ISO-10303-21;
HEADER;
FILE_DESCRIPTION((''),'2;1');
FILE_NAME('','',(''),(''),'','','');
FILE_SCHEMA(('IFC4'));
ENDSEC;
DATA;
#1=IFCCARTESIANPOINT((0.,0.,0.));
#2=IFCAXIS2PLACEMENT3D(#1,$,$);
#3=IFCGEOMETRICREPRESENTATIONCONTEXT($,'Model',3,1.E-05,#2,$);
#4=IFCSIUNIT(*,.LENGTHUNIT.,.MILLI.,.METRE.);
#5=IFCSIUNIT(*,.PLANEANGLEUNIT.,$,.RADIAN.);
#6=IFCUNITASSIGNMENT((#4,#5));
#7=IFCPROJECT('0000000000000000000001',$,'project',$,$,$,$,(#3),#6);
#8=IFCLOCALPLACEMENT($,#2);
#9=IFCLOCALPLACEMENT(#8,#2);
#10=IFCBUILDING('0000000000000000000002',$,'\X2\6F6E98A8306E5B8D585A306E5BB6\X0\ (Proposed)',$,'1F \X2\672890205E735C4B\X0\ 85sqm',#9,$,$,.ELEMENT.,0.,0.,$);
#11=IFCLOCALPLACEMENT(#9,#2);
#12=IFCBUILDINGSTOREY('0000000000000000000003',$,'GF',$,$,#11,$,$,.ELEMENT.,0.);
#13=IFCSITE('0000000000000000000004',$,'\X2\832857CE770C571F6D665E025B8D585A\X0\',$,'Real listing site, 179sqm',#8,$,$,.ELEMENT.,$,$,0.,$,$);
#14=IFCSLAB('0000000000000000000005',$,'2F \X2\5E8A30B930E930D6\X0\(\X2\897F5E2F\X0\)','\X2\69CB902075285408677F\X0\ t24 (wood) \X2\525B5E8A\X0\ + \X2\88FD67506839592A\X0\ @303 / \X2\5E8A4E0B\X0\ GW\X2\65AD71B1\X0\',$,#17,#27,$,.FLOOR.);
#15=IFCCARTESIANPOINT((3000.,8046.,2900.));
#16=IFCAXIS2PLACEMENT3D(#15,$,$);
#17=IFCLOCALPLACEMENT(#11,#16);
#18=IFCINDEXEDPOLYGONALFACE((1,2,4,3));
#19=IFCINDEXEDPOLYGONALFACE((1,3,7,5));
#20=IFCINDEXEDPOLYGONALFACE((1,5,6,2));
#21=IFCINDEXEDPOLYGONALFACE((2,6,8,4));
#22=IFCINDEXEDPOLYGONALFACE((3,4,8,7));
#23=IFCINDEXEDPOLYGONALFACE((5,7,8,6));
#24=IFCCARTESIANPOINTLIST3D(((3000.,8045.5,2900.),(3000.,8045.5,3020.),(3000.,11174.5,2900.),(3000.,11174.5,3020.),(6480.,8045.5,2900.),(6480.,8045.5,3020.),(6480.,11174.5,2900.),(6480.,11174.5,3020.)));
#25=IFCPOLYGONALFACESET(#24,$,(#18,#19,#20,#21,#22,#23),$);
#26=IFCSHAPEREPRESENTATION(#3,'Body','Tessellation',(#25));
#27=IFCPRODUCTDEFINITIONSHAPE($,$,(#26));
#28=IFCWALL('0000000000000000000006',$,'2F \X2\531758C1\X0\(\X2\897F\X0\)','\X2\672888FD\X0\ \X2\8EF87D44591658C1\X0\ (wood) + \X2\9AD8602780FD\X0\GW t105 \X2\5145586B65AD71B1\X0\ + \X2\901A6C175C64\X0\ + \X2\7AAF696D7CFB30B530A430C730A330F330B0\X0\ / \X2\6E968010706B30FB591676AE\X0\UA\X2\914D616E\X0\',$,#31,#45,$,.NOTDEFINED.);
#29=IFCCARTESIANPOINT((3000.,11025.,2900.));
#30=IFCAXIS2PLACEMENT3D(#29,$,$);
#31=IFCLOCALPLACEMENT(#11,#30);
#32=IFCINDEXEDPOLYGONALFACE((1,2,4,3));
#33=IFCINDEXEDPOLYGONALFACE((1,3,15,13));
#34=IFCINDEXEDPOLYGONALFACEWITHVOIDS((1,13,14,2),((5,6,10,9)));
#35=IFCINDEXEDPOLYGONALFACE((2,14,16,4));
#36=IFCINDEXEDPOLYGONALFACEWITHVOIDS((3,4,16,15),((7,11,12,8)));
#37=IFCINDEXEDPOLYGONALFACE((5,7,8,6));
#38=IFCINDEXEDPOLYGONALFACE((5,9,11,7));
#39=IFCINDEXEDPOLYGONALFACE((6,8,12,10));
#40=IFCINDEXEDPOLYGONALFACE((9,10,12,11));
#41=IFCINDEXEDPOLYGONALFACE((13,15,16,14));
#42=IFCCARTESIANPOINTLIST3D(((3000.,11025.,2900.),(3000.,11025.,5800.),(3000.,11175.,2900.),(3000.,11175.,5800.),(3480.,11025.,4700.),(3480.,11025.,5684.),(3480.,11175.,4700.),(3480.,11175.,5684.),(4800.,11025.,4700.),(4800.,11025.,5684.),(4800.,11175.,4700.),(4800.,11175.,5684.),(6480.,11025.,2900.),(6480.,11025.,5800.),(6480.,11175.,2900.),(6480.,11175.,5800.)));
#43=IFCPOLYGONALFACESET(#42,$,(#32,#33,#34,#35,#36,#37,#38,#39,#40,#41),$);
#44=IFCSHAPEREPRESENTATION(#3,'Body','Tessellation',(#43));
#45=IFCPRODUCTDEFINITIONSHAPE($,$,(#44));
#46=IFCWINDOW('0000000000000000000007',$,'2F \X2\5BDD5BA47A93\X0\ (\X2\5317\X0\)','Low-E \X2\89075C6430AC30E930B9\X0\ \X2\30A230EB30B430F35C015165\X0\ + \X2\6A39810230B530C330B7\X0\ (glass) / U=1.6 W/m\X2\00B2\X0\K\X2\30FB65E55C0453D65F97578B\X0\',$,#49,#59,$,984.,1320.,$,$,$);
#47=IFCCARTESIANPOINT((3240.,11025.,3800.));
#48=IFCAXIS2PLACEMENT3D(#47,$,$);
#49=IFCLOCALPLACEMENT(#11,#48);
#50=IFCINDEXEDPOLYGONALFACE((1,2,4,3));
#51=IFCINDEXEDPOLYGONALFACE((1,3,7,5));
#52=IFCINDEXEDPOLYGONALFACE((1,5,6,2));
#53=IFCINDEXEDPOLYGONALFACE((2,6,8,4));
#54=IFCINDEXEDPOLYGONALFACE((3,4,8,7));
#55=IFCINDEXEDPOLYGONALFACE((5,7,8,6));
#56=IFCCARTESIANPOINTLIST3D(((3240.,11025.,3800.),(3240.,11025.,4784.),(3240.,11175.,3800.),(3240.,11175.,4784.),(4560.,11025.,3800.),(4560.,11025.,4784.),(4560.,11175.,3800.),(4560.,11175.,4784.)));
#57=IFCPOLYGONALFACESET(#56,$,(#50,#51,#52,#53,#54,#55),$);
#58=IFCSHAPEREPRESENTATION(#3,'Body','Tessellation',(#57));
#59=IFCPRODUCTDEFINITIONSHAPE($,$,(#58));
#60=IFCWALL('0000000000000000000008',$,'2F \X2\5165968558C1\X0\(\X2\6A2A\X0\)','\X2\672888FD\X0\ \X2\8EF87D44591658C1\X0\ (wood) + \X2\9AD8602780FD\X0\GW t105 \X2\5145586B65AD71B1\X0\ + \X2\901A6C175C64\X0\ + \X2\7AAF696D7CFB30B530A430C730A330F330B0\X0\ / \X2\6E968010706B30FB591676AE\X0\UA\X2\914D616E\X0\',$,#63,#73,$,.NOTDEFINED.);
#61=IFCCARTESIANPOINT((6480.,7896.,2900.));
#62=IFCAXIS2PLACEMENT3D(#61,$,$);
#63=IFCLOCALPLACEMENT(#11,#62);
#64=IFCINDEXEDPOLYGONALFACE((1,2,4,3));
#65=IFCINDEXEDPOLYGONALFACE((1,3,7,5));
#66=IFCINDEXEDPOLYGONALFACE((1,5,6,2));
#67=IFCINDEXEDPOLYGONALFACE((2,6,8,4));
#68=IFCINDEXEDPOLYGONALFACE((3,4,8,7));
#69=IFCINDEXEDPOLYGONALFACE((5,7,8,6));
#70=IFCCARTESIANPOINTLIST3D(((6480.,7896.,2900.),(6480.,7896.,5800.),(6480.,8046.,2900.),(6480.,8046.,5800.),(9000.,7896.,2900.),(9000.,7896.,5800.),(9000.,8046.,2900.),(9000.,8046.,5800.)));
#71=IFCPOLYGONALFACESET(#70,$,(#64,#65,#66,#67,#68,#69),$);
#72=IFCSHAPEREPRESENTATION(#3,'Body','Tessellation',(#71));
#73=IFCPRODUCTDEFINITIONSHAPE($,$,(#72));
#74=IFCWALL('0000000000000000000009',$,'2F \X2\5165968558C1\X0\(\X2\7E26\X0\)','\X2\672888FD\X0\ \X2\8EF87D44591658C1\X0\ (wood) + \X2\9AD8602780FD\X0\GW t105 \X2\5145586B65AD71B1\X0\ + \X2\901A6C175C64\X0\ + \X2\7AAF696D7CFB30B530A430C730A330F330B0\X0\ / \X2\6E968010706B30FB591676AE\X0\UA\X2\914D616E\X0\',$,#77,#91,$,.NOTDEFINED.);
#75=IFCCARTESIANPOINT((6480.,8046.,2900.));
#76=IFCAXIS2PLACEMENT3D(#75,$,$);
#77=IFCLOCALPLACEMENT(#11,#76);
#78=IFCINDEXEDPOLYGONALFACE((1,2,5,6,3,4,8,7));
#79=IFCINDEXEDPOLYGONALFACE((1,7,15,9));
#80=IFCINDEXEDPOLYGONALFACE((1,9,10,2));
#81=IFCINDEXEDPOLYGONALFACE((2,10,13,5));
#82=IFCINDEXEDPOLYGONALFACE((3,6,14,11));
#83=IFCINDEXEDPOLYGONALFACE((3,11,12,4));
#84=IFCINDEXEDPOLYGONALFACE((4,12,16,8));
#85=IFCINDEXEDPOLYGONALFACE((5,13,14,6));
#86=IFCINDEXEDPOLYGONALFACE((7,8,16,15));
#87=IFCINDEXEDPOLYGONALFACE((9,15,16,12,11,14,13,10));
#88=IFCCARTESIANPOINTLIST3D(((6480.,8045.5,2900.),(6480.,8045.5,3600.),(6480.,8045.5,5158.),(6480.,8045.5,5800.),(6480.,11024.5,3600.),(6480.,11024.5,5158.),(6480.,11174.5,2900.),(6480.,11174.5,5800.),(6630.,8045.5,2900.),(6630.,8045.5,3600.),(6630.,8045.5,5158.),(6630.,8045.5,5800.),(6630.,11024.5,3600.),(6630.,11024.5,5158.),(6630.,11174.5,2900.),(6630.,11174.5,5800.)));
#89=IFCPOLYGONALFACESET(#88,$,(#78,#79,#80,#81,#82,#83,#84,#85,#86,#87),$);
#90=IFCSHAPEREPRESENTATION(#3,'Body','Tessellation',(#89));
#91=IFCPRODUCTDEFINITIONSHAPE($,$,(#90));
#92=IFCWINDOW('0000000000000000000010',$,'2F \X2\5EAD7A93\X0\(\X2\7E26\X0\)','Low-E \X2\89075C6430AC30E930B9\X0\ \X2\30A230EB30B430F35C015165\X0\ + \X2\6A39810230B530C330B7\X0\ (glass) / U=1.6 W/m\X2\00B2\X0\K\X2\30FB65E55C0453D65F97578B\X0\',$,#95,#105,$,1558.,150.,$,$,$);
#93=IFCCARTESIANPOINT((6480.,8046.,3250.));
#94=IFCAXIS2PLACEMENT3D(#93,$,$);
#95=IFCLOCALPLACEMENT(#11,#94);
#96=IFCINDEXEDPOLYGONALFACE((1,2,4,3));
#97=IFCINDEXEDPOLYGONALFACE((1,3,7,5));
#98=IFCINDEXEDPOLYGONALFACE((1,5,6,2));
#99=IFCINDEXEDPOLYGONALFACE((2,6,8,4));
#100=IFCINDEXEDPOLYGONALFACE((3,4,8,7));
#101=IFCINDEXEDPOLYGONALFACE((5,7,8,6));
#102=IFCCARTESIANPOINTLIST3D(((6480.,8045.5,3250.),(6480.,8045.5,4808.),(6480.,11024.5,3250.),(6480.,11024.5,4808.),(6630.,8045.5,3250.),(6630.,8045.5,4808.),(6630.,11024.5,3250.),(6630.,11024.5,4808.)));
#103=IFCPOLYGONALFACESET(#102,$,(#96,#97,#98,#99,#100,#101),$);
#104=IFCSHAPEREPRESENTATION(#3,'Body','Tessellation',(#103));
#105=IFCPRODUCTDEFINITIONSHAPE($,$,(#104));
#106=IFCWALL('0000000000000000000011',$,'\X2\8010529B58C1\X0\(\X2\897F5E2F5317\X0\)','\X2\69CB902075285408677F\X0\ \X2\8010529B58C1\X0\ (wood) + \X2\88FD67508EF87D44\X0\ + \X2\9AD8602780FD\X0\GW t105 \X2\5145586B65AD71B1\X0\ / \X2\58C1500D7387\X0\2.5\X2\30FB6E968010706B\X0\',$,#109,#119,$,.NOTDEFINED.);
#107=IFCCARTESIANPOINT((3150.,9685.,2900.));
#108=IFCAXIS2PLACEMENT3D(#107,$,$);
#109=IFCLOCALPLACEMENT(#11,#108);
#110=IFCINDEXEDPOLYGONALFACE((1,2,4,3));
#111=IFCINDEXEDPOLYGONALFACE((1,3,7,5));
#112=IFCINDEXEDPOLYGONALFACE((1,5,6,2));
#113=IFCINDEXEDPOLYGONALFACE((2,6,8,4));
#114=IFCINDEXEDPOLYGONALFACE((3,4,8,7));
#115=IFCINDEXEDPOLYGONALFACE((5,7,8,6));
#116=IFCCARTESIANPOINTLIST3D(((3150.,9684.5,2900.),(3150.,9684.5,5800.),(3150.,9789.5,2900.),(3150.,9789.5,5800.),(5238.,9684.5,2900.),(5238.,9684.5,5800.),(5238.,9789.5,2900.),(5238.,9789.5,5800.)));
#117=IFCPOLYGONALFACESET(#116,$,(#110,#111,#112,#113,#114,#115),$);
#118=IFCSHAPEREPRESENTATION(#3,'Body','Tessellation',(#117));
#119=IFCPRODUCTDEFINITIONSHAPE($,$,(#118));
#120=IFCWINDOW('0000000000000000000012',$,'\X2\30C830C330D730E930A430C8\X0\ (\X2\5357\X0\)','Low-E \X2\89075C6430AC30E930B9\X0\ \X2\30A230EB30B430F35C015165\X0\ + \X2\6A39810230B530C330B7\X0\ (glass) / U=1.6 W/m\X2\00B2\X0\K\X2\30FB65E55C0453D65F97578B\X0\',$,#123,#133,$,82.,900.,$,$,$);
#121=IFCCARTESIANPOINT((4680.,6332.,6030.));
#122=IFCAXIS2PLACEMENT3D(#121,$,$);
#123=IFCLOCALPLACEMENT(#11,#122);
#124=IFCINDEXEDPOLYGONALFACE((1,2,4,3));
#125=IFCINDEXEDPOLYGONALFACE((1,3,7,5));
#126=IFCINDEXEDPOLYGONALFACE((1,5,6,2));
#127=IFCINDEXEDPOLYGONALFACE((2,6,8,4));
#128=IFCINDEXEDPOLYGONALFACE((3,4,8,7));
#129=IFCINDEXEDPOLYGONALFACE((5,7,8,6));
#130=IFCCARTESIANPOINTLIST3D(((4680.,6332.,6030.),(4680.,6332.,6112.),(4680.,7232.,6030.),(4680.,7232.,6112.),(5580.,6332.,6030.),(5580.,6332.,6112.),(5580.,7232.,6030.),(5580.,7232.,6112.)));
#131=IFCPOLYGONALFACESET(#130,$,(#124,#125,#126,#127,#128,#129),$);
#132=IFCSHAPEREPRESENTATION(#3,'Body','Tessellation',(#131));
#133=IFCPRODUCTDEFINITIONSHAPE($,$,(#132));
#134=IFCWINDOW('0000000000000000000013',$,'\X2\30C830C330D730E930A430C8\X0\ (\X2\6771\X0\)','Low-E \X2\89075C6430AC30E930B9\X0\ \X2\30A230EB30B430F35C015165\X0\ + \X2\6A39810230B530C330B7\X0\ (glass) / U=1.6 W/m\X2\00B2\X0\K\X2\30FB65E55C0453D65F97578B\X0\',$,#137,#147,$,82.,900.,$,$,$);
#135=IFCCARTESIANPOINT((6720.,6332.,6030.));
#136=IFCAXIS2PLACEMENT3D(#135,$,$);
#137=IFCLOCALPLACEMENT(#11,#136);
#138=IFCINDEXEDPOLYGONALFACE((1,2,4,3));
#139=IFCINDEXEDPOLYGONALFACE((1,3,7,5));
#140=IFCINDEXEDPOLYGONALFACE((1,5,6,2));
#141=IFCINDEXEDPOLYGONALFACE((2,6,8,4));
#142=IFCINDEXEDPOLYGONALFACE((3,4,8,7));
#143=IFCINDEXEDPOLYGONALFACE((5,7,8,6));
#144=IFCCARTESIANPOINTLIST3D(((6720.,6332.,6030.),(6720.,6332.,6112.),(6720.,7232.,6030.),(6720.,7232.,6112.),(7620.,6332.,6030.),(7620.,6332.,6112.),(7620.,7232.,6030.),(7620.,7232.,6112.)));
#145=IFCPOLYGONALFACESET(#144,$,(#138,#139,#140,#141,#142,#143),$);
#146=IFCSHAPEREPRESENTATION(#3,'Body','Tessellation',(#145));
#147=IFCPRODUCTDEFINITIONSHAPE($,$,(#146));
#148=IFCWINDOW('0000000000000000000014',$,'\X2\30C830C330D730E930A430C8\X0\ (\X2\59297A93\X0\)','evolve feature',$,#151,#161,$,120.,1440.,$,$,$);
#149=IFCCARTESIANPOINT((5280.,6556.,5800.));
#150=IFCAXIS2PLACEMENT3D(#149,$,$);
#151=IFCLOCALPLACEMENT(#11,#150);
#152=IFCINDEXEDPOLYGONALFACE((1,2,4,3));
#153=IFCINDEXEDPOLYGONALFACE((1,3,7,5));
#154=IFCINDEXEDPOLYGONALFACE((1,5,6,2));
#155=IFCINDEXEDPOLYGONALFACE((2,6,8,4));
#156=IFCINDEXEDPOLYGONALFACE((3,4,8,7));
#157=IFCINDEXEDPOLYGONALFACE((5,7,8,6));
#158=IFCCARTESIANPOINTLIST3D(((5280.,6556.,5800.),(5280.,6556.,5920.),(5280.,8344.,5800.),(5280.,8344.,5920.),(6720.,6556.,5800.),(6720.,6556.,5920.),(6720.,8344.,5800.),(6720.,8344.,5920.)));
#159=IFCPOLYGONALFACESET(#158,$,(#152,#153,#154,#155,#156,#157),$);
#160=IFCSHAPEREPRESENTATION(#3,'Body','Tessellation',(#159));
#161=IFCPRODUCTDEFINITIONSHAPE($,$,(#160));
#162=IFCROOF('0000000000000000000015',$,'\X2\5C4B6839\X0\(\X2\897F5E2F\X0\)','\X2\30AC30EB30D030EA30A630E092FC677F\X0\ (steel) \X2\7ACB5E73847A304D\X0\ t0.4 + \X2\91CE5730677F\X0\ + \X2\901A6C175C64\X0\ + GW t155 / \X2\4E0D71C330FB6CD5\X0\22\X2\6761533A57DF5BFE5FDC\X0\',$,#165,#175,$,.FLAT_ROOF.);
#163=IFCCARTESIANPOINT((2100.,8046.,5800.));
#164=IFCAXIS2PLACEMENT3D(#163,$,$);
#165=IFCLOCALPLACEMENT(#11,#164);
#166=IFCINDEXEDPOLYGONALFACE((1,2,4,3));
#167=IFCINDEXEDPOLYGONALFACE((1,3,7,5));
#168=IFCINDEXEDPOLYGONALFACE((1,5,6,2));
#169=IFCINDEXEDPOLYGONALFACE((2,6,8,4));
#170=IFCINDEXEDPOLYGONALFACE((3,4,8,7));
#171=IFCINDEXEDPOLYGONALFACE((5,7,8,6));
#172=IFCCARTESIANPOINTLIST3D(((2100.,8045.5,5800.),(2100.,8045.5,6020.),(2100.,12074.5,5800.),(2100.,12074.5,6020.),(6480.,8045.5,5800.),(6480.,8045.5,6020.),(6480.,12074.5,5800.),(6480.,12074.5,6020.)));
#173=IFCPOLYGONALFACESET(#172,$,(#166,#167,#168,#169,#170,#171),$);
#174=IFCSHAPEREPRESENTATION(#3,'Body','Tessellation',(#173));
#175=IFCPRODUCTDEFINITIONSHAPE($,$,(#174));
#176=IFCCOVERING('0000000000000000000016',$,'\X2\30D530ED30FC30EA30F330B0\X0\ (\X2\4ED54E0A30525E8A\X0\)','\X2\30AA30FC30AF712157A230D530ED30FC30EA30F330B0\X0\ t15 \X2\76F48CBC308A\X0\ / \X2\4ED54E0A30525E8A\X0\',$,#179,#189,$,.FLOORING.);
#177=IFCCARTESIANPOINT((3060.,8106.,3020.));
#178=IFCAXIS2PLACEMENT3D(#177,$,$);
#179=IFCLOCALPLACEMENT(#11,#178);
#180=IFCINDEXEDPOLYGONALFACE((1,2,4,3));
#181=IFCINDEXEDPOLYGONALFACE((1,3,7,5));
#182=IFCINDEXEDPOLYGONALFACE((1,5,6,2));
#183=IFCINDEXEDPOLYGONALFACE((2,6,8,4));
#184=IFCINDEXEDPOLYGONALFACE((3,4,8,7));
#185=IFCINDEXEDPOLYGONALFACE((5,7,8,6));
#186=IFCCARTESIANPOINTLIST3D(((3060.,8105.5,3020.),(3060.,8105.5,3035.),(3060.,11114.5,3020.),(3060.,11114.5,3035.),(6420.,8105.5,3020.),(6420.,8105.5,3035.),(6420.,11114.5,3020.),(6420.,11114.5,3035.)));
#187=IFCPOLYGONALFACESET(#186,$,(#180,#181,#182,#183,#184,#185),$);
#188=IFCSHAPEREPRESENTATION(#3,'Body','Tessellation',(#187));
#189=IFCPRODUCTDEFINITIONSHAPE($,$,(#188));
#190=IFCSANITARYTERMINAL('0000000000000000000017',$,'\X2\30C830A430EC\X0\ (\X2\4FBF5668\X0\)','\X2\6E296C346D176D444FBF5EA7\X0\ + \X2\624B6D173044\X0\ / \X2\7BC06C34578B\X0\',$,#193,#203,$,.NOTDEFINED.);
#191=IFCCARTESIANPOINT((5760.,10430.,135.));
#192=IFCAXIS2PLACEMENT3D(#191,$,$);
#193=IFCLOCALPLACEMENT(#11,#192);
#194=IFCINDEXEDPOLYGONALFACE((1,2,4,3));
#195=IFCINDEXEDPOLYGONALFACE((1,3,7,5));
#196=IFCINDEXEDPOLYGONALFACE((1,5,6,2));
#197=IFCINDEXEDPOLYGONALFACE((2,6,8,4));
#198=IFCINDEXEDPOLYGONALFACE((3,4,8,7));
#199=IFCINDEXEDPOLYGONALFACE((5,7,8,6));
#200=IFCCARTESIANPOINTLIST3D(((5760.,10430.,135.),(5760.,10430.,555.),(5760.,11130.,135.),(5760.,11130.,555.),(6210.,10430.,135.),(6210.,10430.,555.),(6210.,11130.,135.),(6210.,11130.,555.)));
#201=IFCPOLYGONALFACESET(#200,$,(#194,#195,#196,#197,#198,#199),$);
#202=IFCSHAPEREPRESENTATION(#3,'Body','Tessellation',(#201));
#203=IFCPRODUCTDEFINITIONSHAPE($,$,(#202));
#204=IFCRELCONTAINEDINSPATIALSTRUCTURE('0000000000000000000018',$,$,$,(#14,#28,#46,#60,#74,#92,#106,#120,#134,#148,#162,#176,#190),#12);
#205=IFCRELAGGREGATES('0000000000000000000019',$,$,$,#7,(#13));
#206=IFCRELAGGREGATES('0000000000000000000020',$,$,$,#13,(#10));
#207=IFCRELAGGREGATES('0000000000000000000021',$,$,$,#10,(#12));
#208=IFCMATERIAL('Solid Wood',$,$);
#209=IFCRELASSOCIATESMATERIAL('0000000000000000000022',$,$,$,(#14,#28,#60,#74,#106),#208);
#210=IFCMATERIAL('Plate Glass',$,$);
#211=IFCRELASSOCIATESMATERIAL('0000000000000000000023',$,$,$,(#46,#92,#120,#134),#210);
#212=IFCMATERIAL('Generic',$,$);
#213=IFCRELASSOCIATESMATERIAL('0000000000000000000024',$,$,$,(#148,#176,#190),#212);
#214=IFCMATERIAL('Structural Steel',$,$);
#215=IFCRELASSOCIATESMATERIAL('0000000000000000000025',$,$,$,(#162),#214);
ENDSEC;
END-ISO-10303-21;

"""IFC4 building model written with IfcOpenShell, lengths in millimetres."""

from ifc_helpers import new_model, si_unit, frame, frame_2d, origin, place, context, project, spatial, rectangle, extrude, material, element, fill, save


model = new_model("IFC4")

# Units and contexts
model_context = context("Model", 3, precision=1e-05, world=origin())
ifc_project = project(units=[si_unit("LENGTHUNIT", "METRE", prefix="MILLI"), si_unit("PLANEANGLEUNIT", "RADIAN")], contexts=[model_context])

# Site, building, storey
site_placement = place(None, origin())
site = spatial("IfcSite", under=ifc_project, at=site_placement, Name="茨城県土浦市宍塚", ObjectType="Real listing site, 179sqm", CompositionType="ELEMENT", RefElevation=0.0)
building_placement = place(site_placement, origin())
building = spatial("IfcBuilding", under=site, at=building_placement, Name="潮風の宍塚の家 (Proposed)", ObjectType="1F 木造平屋 85sqm", CompositionType="ELEMENT", ElevationOfRefHeight=0.0, ElevationOfTerrain=0.0)
storey_placement = place(building_placement, origin())
storey = spatial("IfcBuildingStorey", under=building, at=storey_placement, Name="GF", CompositionType="ELEMENT", Elevation=0.0)

# Slab
ifc_material_1 = material(Name="Solid Wood")
slab_placement = place(storey_placement, frame((3000.0, 8046.0, 2900.0)))
element("IfcSlab", 1, at=slab_placement, inside=storey, material=ifc_material_1, Name="2F 床スラブ(西帯)", Description="構造用合板 t24 (wood) 剛床 + 製材根太 @303 / 床下 GW断熱", PredefinedType="FLOOR", context=model_context, shape_type="SweptSolid", body=[
    extrude(rectangle(XDim=3480.0, YDim=3129.0, at=frame_2d((1740.0, 1564.0))), frame((3000.0, 8046.0, 2900.0)), (0.0, 0.0, 1.0), 120.0),
])

# Wall, opening, window
wall_1_placement = place(storey_placement, frame((3000.0, 11025.0, 2900.0)))
wall_1 = element("IfcWall", 2, at=wall_1_placement, inside=storey, material=ifc_material_1, Name="2F 北壁(西)", Description="木製 軸組外壁 (wood) + 高性能GW t105 充填断熱 + 通気層 + 窯業系サイディング / 準耐火・外皮UA配慮", PredefinedType="NOTDEFINED", context=model_context, shape_type="SweptSolid", body=[
    extrude(rectangle(XDim=3480.0, YDim=150.0, at=frame_2d((1740.0, 75.0))), frame((3000.0, 11025.0, 2900.0)), (0.0, 0.0, 1.0), 2900.0),
])
opening_1_placement = place(storey_placement, frame((3240.0, 11025.0, 3800.0)))
opening_1 = element("IfcOpeningElement", 3, at=opening_1_placement, cuts=wall_1, PredefinedType="NOTDEFINED", context=model_context, shape_type="SweptSolid", body=[
    extrude(rectangle(XDim=1320.0, YDim=150.0, at=frame_2d((660.0, 75.0))), frame((3240.0, 11025.0, 3800.0)), (0.0, 0.0, 1.0), 984.0),
])
ifc_material_2 = material(Name="Plate Glass")
window_1_placement = place(storey_placement, frame((3240.0, 11025.0, 3800.0)))
window_1 = element("IfcWindow", 4, at=window_1_placement, inside=storey, material=ifc_material_2, Name="2F 寝室窓 (北)", Description="Low-E 複層ガラス アルゴン封入 + 樹脂サッシ (glass) / U=1.6 W/m²K・日射取得型", OverallHeight=984.0, OverallWidth=1320.0, context=model_context, shape_type="SweptSolid", body=[
    extrude(rectangle(XDim=1320.0, YDim=150.0, at=frame_2d((660.0, 75.0))), frame((3240.0, 11025.0, 3800.0)), (0.0, 0.0, 1.0), 984.0),
])
fill(opening_1, window_1)

# Wall
wall_2_placement = place(storey_placement, frame((6480.0, 7896.0, 2900.0)))
element("IfcWall", 5, at=wall_2_placement, inside=storey, material=ifc_material_1, Name="2F 入隅壁(横)", Description="木製 軸組外壁 (wood) + 高性能GW t105 充填断熱 + 通気層 + 窯業系サイディング / 準耐火・外皮UA配慮", PredefinedType="NOTDEFINED", context=model_context, shape_type="SweptSolid", body=[
    extrude(rectangle(XDim=2520.0, YDim=150.0, at=frame_2d((1260.0, 75.0))), frame((6480.0, 7896.0, 2900.0)), (0.0, 0.0, 1.0), 2900.0),
])

# Wall, opening, window
wall_3_placement = place(storey_placement, frame((6480.0, 8046.0, 2900.0)))
wall_3 = element("IfcWall", 6, at=wall_3_placement, inside=storey, material=ifc_material_1, Name="2F 入隅壁(縦)", Description="木製 軸組外壁 (wood) + 高性能GW t105 充填断熱 + 通気層 + 窯業系サイディング / 準耐火・外皮UA配慮", PredefinedType="NOTDEFINED", context=model_context, shape_type="SweptSolid", body=[
    extrude(rectangle(XDim=150.0, YDim=3129.0, at=frame_2d((75.0, 1564.0))), frame((6480.0, 8046.0, 2900.0)), (0.0, 0.0, 1.0), 2900.0),
])
opening_2_placement = place(storey_placement, frame((6480.0, 8046.0, 3250.0)))
opening_2 = element("IfcOpeningElement", 7, at=opening_2_placement, cuts=wall_3, PredefinedType="NOTDEFINED", context=model_context, shape_type="SweptSolid", body=[
    extrude(rectangle(XDim=150.0, YDim=2979.0, at=frame_2d((75.0, 1489.0))), frame((6480.0, 8046.0, 3250.0)), (0.0, 0.0, 1.0), 1558.0),
])
window_2_placement = place(storey_placement, frame((6480.0, 8046.0, 3250.0)))
window_2 = element("IfcWindow", 8, at=window_2_placement, inside=storey, material=ifc_material_2, Name="2F 庭窓(縦)", Description="Low-E 複層ガラス アルゴン封入 + 樹脂サッシ (glass) / U=1.6 W/m²K・日射取得型", OverallHeight=1558.0, OverallWidth=150.0, context=model_context, shape_type="SweptSolid", body=[
    extrude(rectangle(XDim=150.0, YDim=2979.0, at=frame_2d((75.0, 1489.0))), frame((6480.0, 8046.0, 3250.0)), (0.0, 0.0, 1.0), 1558.0),
])
fill(opening_2, window_2)

# Wall
wall_4_placement = place(storey_placement, frame((3150.0, 9685.0, 2900.0)))
element("IfcWall", 9, at=wall_4_placement, inside=storey, material=ifc_material_1, Name="耐力壁(西帯北)", Description="構造用合板 耐力壁 (wood) + 製材軸組 + 高性能GW t105 充填断熱 / 壁倍率2.5・準耐火", PredefinedType="NOTDEFINED", context=model_context, shape_type="SweptSolid", body=[
    extrude(rectangle(XDim=2088.0, YDim=105.0, at=frame_2d((1044.0, 52.0))), frame((3150.0, 9685.0, 2900.0)), (0.0, 0.0, 1.0), 2900.0),
])

# Windows
window_3_placement = place(storey_placement, frame((4680.0, 6332.0, 6030.0)))
element("IfcWindow", 10, at=window_3_placement, inside=storey, material=ifc_material_2, Name="トップライト (南)", Description="Low-E 複層ガラス アルゴン封入 + 樹脂サッシ (glass) / U=1.6 W/m²K・日射取得型", OverallHeight=82.0, OverallWidth=900.0, context=model_context, shape_type="SweptSolid", body=[
    extrude(rectangle(XDim=900.0, YDim=900.0, at=frame_2d((450.0, 450.0))), frame((4680.0, 6332.0, 6030.0)), (0.0, 0.0, 1.0), 82.0),
])
window_4_placement = place(storey_placement, frame((6720.0, 6332.0, 6030.0)))
element("IfcWindow", 11, at=window_4_placement, inside=storey, material=ifc_material_2, Name="トップライト (東)", Description="Low-E 複層ガラス アルゴン封入 + 樹脂サッシ (glass) / U=1.6 W/m²K・日射取得型", OverallHeight=82.0, OverallWidth=900.0, context=model_context, shape_type="SweptSolid", body=[
    extrude(rectangle(XDim=900.0, YDim=900.0, at=frame_2d((450.0, 450.0))), frame((6720.0, 6332.0, 6030.0)), (0.0, 0.0, 1.0), 82.0),
])
ifc_material_3 = material(Name="Generic")
window_5_placement = place(storey_placement, frame((5280.0, 6556.0, 5800.0)))
element("IfcWindow", 12, at=window_5_placement, inside=storey, material=ifc_material_3, Name="トップライト (天窓)", Description="evolve feature", OverallHeight=120.0, OverallWidth=1440.0, context=model_context, shape_type="SweptSolid", body=[
    extrude(rectangle(XDim=1440.0, YDim=1788.0, at=frame_2d((720.0, 894.0))), frame((5280.0, 6556.0, 5800.0)), (0.0, 0.0, 1.0), 120.0),
])

# Roof
ifc_material_4 = material(Name="Structural Steel")
for number, where, name in (
    (13, (2100.0, 8046.0, 5800.0), "屋根(西帯)"),
):
    element("IfcRoof", number, at=place(storey_placement, frame(where)), inside=storey, material=ifc_material_4, Name=name, Description="ガルバリウム鋼板 (steel) 立平葺き t0.4 + 野地板 + 通気層 + GW t155 / 不燃・法22条区域対応", PredefinedType="FLAT_ROOF", context=model_context, shape_type="SweptSolid", body=[
        extrude(rectangle(XDim=4380.0, YDim=4029.0, at=frame_2d((2190.0, 2014.0))), frame((2100.0, 8046.0, 5800.0)), (0.0, 0.0, 1.0), 220.0),
    ])

# Covering
covering_placement = place(storey_placement, frame((3060.0, 8106.0, 3020.0)))
element("IfcCovering", 14, at=covering_placement, inside=storey, material=ifc_material_3, Name="フローリング (仕上げ床)", Description="オーク無垢フローリング t15 直貼り / 仕上げ床", PredefinedType="FLOORING", context=model_context, shape_type="SweptSolid", body=[
    extrude(rectangle(XDim=3360.0, YDim=3009.0, at=frame_2d((1680.0, 1504.0))), frame((3060.0, 8106.0, 3020.0)), (0.0, 0.0, 1.0), 15.0),
])

# Sanitary terminal
sanitary_terminal_placement = place(storey_placement, frame((5760.0, 10430.0, 135.0)))
element("IfcSanitaryTerminal", 15, at=sanitary_terminal_placement, inside=storey, material=ifc_material_3, Name="トイレ (便器)", Description="温水洗浄便座 + 手洗い / 節水型", PredefinedType="NOTDEFINED", context=model_context, shape_type="SweptSolid", body=[
    extrude(rectangle(XDim=450.0, YDim=700.0, at=frame_2d((225.0, 350.0))), frame((5760.0, 10430.0, 135.0)), (0.0, 0.0, 1.0), 420.0),
])

save(model, "model.ifc")
